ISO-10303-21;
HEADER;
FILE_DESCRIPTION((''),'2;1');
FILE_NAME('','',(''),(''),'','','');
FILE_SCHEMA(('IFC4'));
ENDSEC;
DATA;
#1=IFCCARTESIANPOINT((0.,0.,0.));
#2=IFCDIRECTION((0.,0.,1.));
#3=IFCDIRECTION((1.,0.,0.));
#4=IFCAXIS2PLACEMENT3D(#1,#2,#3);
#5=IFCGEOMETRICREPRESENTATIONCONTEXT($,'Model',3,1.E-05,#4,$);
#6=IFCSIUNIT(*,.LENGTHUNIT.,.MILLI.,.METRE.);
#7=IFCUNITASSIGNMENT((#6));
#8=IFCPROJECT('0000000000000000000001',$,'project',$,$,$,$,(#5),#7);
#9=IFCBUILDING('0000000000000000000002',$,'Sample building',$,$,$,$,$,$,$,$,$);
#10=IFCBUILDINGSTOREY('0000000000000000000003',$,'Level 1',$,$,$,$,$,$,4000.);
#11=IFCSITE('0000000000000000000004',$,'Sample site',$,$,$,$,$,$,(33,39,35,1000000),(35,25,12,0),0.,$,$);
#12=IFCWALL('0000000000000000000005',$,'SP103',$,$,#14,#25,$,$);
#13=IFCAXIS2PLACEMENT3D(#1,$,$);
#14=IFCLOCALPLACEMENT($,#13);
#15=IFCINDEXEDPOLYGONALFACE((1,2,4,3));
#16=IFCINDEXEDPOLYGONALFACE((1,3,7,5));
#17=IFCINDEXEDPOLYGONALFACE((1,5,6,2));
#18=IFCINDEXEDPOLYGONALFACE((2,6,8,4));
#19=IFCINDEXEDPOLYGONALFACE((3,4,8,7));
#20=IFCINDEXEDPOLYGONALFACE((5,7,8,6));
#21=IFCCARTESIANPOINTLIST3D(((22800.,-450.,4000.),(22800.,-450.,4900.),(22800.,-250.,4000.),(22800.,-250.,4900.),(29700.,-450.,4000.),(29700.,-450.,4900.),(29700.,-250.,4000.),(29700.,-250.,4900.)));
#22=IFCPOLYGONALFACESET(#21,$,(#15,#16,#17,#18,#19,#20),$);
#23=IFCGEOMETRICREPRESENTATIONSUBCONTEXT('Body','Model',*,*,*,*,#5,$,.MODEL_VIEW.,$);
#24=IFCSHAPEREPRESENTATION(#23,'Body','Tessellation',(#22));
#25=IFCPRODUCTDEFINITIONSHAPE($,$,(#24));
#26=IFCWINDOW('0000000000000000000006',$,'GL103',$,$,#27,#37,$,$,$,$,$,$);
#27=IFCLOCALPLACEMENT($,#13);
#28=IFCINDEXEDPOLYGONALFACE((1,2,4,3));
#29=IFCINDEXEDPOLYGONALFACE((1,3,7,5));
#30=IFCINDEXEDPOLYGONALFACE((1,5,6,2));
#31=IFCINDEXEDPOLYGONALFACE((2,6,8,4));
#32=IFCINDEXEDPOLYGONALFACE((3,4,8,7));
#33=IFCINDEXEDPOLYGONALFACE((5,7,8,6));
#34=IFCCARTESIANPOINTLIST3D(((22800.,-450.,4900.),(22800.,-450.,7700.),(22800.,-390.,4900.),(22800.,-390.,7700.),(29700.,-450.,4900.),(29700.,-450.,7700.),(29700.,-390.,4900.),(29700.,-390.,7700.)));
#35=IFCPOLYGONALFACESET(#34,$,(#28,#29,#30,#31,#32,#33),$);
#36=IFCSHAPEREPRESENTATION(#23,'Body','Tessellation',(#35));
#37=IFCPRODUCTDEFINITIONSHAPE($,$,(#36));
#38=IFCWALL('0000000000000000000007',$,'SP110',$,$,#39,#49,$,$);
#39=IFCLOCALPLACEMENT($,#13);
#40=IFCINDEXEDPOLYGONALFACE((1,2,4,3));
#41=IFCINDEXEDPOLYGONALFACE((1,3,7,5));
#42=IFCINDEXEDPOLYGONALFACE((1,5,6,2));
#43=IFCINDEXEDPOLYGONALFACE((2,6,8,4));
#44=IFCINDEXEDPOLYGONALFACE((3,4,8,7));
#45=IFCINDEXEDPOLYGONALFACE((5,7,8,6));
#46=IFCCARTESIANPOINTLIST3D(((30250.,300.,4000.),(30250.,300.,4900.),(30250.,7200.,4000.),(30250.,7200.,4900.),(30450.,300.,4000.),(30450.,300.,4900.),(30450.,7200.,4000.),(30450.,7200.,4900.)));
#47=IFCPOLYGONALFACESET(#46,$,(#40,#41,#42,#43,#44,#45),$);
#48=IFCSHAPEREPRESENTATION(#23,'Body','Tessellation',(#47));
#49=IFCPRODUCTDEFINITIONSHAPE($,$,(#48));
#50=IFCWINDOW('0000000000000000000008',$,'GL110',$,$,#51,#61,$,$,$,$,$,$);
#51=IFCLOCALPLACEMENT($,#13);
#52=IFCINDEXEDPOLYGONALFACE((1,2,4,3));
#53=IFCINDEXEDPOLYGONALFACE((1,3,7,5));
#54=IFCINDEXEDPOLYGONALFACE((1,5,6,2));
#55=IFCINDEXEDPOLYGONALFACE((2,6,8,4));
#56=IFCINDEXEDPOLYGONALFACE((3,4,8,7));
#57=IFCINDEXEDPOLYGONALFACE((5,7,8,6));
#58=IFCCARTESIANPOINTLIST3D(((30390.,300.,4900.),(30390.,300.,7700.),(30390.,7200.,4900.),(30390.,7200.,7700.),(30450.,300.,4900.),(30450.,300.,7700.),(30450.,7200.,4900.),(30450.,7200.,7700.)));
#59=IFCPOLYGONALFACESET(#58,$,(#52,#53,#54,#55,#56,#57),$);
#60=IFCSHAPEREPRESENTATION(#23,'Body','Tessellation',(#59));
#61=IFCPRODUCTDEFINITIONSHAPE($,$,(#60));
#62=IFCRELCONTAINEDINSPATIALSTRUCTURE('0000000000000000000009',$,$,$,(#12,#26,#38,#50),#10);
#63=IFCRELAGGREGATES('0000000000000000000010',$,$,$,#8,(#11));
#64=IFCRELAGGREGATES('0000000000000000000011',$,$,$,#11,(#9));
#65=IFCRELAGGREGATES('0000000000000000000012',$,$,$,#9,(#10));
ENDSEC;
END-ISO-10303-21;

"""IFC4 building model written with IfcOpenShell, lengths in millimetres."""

from ifc_helpers import new_model, si_unit, frame, origin_with_axes, place, context, subcontext, project, spatial, indexed_curve, outline, extrude, element, save


model = new_model("IFC4")

# Units and contexts
model_context = context("Model", 3, precision=1e-05, world=origin_with_axes())
body_context = subcontext(model_context, "Body", "Model", "MODEL_VIEW")
ifc_project = project(units=[si_unit("LENGTHUNIT", "METRE", prefix="MILLI")], contexts=[model_context])

# Site, building, storey
site = spatial("IfcSite", under=ifc_project, Name="Sample site", RefLatitude=(33, 39, 35, 1000000), RefLongitude=(35, 25, 12, 0), RefElevation=0.0)
building = spatial("IfcBuilding", under=site, Name="Sample building")
storey = spatial("IfcBuildingStorey", under=building, Name="Level 1", Elevation=4000.0)

# Wall
wall_1_placement = place(None, frame((22800.0, -450.0, 4000.0), z_axis=(0.0, 0.0, 1.0), x_axis=(1.0, 0.0, 0.0)))
element("IfcWall", 1, at=wall_1_placement, inside=storey, Name="SP103", context=body_context, shape_type="SweptSolid", body=[
    extrude(outline(indexed_curve([(0.0, 0.0), (0.0, 200.0), (6900.0, 200.0), (6900.0, 0.0), (0.0, 0.0)], self_intersect=False)), origin_with_axes(), (0.0, 0.0, 1.0), 900.0),
])

# Window
window_1_placement = place(None, frame((22800.0, -450.0, 4900.0), z_axis=(0.0, 0.0, 1.0), x_axis=(1.0, 0.0, 0.0)))
element("IfcWindow", 2, at=window_1_placement, inside=storey, Name="GL103", context=body_context, shape_type="SweptSolid", body=[
    extrude(outline(indexed_curve([(0.0, 0.0), (0.0, 60.0), (6900.0, 60.0), (6900.0, 0.0), (0.0, 0.0)], self_intersect=False)), origin_with_axes(), (0.0, 0.0, 1.0), 2800.0),
])

# Wall
wall_2_placement = place(None, frame((30450.0, 300.0, 4000.0), z_axis=(0.0, 0.0, 1.0), x_axis=(0.0, 1.0, 0.0)))
element("IfcWall", 3, at=wall_2_placement, inside=storey, Name="SP110", context=body_context, shape_type="SweptSolid", body=[
    extrude(outline(indexed_curve([(0.0, 0.0), (0.0, 200.0), (6900.0, 200.0), (6900.0, 0.0), (0.0, 0.0)], self_intersect=False)), origin_with_axes(), (0.0, 0.0, 1.0), 900.0),
])

# Window
window_2_placement = place(None, frame((30450.0, 300.0, 4900.0), z_axis=(0.0, 0.0, 1.0), x_axis=(0.0, 1.0, 0.0)))
element("IfcWindow", 4, at=window_2_placement, inside=storey, Name="GL110", context=body_context, shape_type="SweptSolid", body=[
    extrude(outline(indexed_curve([(0.0, 0.0), (0.0, 60.0), (6900.0, 60.0), (6900.0, 0.0), (0.0, 0.0)], self_intersect=False)), origin_with_axes(), (0.0, 0.0, 1.0), 2800.0),
])

save(model, "model.ifc")
